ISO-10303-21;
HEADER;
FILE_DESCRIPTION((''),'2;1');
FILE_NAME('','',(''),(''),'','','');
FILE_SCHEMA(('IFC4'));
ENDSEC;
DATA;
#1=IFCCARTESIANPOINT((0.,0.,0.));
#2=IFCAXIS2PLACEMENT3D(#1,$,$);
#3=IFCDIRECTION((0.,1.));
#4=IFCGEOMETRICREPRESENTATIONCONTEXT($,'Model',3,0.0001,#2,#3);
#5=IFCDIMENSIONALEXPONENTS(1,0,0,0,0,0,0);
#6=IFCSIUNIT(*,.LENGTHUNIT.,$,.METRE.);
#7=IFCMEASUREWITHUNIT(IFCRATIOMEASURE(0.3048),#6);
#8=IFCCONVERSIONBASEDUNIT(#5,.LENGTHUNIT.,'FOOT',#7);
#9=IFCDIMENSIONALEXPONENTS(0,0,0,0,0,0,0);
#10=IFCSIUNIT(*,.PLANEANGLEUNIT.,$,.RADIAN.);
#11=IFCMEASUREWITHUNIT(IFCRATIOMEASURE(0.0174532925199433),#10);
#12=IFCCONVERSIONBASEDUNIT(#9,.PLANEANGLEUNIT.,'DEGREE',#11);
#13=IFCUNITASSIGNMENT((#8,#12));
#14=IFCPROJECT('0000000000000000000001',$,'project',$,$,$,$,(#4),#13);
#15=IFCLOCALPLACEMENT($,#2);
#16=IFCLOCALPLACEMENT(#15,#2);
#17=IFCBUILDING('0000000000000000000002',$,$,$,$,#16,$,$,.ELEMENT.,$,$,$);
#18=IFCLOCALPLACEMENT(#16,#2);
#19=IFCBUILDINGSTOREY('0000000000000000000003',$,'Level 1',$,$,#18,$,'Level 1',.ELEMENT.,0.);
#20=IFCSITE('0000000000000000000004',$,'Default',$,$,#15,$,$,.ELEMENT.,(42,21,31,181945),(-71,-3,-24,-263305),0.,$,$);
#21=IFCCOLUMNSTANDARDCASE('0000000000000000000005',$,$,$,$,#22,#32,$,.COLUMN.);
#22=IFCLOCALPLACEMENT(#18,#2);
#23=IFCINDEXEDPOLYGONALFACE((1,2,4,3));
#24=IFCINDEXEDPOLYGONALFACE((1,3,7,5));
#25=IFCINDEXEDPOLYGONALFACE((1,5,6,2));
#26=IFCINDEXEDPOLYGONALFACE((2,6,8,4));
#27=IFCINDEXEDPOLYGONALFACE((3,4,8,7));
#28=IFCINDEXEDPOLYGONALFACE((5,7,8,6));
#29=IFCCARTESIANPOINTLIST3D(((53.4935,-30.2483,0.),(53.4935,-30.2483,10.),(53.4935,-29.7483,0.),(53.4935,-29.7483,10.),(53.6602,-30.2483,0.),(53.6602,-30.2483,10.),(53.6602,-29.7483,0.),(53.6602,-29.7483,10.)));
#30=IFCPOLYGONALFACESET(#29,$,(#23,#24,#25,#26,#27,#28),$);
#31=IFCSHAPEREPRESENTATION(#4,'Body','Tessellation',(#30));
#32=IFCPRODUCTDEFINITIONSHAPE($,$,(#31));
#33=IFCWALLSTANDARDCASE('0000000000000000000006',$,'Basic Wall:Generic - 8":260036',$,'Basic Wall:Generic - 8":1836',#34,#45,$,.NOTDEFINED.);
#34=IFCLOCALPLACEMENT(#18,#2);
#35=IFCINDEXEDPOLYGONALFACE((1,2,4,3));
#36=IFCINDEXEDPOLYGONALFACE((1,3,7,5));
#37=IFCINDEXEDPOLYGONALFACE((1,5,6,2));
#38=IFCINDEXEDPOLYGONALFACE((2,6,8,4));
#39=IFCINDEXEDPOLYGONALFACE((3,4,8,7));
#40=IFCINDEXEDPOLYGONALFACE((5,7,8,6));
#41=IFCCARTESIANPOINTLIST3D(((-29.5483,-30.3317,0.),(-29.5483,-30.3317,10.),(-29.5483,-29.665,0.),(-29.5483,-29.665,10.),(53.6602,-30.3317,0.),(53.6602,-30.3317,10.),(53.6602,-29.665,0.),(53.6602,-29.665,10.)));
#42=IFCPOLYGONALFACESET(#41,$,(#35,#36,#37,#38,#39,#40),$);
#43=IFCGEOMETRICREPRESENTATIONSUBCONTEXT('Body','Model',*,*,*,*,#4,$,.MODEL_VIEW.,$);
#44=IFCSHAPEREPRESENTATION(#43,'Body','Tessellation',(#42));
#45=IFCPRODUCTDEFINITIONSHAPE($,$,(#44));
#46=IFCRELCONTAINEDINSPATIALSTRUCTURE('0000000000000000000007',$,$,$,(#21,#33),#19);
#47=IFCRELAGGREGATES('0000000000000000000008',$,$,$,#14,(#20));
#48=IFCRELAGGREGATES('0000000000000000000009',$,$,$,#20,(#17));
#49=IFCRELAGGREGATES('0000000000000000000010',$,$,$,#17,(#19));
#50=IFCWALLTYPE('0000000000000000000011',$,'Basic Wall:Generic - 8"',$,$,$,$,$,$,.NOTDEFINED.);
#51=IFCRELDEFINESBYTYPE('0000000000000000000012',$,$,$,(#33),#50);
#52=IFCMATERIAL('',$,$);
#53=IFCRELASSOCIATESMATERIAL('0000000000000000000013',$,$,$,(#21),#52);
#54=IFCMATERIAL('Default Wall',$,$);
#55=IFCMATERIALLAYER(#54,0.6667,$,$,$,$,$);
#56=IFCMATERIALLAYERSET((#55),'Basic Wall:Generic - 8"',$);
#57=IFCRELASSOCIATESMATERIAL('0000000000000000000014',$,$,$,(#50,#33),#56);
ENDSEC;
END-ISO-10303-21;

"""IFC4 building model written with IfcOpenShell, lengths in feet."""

from ifc_helpers import new_model, entity, si_unit, converted_unit, direction, frame, frame_2d, origin, place, context, subcontext, project, spatial, rectangle, extrude, material, layer, layer_set, layer_usage, type_object, element, save


model = new_model("IFC4")

# Units and contexts
model_context = context("Model", 3, precision=0.0001, world=origin(), true_north=direction((0.0, 1.0)))
body_context = subcontext(model_context, "Body", "Model", "MODEL_VIEW")
ifc_project = project(units=[converted_unit("LENGTHUNIT", "FOOT", entity("IfcRatioMeasure", 0.3048), si_unit("LENGTHUNIT", "METRE"), dimensions=[1, 0, 0, 0, 0, 0, 0]), converted_unit("PLANEANGLEUNIT", "DEGREE", entity("IfcRatioMeasure", 0.0174532925199433), si_unit("PLANEANGLEUNIT", "RADIAN"), dimensions=[0, 0, 0, 0, 0, 0, 0])], contexts=[model_context])

# Site, building, storey
site_placement = place(None, origin())
site = spatial("IfcSite", under=ifc_project, at=site_placement, Name="Default", CompositionType="ELEMENT", RefLatitude=(42, 21, 31, 181945), RefLongitude=(-71, -3, -24, -263305), RefElevation=0.0)
building_placement = place(site_placement, origin())
building = spatial("IfcBuilding", under=site, at=building_placement, CompositionType="ELEMENT")
storey_placement = place(building_placement, origin())
storey = spatial("IfcBuildingStorey", under=building, at=storey_placement, Name="Level 1", LongName="Level 1", CompositionType="ELEMENT", Elevation=0.0)

# Column
ifc_material_1 = material(Name="")
wall_placement = place(storey_placement, frame((53.6602, -29.9983, 0.0), z_axis=(0.0, 0.0, 1.0), x_axis=(-1.0, 0.0, 0.0)))
for number, where, z_axis, x_axis in (
    (1, (0.0833, 0.0, 0.0), (0.0, 0.0, 1.0), (1.0, 0.0, 0.0)),
):
    element("IfcColumnStandardCase", number, at=place(wall_placement, frame(where, z_axis=z_axis, x_axis=x_axis)), inside=storey, material=ifc_material_1, PredefinedType="COLUMN", context=model_context, shape_type="SweptSolid", body=[
        extrude(rectangle(XDim=0.1667, YDim=0.5), origin(), (0.0, 0.0, 1.0), 10.0),
    ])

# Wall
ifc_material_2 = material(Name="Default Wall")
ifc_layer = layer(ifc_material_2, 0.6667)
ifc_layer_set = layer_set([ifc_layer], Name="Basic Wall:Generic - 8\"")
ifc_layer_usage = layer_usage(ifc_layer_set, "AXIS2", "NEGATIVE", 0.3333)
wall_type = type_object("IfcWallType", Name="Basic Wall:Generic - 8\"", PredefinedType="NOTDEFINED", material=ifc_layer_set)
element("IfcWallStandardCase", 2, at=wall_placement, inside=storey, type_object=wall_type, material=ifc_layer_usage, Name="Basic Wall:Generic - 8\":260036", ObjectType="Basic Wall:Generic - 8\":1836", PredefinedType="NOTDEFINED", context=body_context, shape_type="SweptSolid", body=[
    extrude(rectangle(XDim=83.2085, YDim=0.6667, at=frame_2d((41.6043, 0.0), x_axis=(-1.0, 0.0))), origin(), (0.0, 0.0, 1.0), 10.0),
])

save(model, "model.ifc")
